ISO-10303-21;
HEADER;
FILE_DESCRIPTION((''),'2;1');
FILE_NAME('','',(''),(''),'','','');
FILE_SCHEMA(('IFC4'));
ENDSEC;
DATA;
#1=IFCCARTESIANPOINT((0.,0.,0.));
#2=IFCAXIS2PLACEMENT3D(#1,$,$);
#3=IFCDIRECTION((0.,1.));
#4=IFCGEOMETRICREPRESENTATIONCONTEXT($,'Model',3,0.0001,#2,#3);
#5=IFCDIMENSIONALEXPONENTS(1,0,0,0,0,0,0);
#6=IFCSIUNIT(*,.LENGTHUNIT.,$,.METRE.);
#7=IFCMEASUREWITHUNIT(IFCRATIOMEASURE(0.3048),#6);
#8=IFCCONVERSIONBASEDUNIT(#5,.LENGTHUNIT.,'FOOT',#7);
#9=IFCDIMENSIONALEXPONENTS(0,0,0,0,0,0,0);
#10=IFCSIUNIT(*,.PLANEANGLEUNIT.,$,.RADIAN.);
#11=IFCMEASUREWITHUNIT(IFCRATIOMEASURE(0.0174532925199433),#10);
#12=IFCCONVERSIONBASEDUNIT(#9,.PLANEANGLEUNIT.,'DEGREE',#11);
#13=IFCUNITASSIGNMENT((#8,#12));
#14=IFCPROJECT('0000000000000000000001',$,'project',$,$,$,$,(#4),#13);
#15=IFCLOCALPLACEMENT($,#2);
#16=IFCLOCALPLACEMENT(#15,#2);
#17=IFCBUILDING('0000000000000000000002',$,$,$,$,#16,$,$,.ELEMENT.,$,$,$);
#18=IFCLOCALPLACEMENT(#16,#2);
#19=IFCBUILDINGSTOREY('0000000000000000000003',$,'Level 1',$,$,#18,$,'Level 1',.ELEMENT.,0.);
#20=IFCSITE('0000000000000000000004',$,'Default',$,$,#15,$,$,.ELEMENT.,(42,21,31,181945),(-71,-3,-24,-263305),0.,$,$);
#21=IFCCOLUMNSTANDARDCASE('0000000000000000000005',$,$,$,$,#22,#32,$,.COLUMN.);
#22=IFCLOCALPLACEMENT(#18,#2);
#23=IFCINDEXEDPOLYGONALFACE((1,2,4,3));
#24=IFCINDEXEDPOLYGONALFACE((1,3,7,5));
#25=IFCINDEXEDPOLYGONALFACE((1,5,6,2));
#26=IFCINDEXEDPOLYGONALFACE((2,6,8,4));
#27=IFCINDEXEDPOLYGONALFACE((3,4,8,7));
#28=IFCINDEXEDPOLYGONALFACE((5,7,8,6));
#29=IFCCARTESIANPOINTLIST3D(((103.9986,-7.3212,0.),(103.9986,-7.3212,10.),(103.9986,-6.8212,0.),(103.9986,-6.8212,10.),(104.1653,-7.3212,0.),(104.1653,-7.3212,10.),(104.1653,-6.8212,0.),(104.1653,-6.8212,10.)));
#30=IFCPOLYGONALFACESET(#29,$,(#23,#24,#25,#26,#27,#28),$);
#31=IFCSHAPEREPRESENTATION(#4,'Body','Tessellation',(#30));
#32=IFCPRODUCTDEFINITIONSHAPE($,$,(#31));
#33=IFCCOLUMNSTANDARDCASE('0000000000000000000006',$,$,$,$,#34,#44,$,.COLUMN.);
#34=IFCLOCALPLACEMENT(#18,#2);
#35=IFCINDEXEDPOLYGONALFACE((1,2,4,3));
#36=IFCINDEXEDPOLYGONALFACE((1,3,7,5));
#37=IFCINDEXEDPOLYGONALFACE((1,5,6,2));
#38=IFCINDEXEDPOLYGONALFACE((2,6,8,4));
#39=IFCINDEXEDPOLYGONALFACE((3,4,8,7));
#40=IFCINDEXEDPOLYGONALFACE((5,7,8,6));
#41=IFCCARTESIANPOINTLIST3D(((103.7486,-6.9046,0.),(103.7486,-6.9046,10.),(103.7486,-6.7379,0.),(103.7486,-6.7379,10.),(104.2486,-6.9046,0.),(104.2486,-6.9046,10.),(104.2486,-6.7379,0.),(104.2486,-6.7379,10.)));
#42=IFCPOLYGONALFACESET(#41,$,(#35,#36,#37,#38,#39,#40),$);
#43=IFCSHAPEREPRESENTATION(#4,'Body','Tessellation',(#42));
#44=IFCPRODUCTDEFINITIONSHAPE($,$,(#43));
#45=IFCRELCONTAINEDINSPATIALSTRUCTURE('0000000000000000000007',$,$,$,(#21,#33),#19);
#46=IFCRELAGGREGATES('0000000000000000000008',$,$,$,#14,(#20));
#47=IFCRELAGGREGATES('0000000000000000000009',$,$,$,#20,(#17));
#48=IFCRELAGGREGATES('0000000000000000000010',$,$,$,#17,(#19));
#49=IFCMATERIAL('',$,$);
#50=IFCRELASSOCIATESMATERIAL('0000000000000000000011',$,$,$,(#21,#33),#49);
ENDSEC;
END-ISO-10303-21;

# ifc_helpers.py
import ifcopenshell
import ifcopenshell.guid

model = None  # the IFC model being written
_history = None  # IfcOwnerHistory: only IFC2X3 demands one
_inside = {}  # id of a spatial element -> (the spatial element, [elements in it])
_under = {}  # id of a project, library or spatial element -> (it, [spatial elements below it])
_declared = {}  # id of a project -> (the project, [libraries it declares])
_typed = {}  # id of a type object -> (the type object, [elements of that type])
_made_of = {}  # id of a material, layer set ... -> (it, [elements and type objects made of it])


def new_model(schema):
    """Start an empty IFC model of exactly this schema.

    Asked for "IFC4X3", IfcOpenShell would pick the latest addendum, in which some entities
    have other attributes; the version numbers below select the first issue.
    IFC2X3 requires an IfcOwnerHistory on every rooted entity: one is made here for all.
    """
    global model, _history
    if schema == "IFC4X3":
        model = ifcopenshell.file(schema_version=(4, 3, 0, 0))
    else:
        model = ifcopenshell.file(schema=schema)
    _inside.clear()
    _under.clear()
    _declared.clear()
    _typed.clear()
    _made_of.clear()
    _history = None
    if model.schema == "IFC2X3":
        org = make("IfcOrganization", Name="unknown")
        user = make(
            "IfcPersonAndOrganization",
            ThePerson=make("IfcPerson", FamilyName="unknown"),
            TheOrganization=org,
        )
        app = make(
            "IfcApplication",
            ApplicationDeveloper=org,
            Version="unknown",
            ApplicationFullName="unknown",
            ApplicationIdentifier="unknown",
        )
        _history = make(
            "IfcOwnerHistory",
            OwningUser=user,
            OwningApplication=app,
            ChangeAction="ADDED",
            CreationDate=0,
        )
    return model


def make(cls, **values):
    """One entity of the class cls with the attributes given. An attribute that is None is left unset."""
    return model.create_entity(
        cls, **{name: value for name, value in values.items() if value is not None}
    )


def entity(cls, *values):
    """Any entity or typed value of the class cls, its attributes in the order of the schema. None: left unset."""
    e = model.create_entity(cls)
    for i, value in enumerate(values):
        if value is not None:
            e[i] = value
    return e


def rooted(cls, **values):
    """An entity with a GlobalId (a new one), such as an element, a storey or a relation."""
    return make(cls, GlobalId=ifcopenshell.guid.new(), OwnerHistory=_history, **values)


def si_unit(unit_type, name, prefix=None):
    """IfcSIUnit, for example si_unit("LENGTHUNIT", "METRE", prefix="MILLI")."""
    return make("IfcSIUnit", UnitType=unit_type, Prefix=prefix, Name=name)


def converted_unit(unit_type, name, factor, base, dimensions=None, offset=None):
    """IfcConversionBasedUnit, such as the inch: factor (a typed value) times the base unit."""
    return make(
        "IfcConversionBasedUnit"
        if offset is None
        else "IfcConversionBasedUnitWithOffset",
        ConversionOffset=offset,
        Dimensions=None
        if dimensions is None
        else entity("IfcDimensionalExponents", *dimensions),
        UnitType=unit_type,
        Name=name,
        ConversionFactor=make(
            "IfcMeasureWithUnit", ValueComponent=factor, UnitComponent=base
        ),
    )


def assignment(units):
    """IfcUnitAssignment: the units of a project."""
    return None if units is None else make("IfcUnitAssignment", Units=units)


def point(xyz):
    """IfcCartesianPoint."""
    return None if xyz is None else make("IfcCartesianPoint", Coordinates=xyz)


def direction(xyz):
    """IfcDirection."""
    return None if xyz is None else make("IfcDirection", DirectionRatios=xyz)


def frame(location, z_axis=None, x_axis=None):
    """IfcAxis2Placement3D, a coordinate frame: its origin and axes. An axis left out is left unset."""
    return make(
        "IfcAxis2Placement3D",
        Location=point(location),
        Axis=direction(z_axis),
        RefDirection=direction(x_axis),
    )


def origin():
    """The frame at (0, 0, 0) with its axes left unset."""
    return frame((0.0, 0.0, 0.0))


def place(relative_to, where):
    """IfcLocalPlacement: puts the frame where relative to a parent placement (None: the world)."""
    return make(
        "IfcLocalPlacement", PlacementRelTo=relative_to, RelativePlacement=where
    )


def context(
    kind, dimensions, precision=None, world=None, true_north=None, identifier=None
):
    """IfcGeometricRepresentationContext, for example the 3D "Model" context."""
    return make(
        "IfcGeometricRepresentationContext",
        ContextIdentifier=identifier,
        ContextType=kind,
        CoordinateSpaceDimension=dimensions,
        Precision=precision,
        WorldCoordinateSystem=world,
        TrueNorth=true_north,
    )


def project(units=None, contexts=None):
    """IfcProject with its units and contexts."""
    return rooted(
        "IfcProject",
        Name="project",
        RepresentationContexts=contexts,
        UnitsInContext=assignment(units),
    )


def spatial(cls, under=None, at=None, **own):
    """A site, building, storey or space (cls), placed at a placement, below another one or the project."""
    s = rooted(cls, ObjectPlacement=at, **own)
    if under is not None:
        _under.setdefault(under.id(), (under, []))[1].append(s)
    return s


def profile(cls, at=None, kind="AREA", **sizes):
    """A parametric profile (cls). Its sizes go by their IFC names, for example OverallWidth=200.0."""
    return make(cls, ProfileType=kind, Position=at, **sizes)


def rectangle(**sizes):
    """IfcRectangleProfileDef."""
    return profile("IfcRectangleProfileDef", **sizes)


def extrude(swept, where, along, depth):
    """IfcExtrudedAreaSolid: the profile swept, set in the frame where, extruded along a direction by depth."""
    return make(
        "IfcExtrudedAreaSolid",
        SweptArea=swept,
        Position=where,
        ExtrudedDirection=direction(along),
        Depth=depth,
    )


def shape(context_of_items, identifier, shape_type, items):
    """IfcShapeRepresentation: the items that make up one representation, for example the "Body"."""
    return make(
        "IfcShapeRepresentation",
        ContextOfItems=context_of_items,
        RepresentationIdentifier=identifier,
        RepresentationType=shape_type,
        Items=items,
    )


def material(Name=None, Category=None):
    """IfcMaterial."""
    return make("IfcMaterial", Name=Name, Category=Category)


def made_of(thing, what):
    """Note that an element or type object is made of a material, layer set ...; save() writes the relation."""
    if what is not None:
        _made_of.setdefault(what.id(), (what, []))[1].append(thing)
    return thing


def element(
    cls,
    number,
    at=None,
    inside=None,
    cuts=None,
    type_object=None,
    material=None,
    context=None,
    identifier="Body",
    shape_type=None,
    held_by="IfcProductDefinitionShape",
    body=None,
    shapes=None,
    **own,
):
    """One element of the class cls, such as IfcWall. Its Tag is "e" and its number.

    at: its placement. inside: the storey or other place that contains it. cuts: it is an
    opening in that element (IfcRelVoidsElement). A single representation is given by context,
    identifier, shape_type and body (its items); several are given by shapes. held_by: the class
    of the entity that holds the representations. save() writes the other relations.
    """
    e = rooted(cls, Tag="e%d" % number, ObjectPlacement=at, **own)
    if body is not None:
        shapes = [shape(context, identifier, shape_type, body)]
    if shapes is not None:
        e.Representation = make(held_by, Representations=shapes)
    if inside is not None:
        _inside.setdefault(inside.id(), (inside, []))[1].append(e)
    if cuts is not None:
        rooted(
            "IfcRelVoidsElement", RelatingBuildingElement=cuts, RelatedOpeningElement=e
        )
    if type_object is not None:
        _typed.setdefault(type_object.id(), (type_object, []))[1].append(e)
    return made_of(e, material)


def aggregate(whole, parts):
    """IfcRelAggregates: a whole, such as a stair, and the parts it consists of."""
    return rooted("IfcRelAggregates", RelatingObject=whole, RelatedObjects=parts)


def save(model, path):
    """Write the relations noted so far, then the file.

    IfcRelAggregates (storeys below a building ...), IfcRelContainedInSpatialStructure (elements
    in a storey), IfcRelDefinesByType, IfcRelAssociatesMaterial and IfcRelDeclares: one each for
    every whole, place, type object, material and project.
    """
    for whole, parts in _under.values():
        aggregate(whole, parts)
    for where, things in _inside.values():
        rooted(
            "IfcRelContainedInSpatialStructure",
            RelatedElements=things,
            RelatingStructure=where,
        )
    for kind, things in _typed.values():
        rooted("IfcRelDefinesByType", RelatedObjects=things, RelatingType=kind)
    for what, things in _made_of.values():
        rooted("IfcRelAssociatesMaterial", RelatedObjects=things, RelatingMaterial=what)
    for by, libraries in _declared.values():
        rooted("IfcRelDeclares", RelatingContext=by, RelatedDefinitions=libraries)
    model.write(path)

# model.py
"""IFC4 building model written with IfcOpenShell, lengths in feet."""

from ifc_helpers import new_model, entity, si_unit, converted_unit, direction, frame, origin, place, context, project, spatial, rectangle, extrude, material, element, save


model = new_model("IFC4")

# Units and contexts
model_context = context("Model", 3, precision=0.0001, world=origin(), true_north=direction((0.0, 1.0)))
ifc_project = project(units=[converted_unit("LENGTHUNIT", "FOOT", entity("IfcRatioMeasure", 0.3048), si_unit("LENGTHUNIT", "METRE"), dimensions=[1, 0, 0, 0, 0, 0, 0]), converted_unit("PLANEANGLEUNIT", "DEGREE", entity("IfcRatioMeasure", 0.0174532925199433), si_unit("PLANEANGLEUNIT", "RADIAN"), dimensions=[0, 0, 0, 0, 0, 0, 0])], contexts=[model_context])

# Site, building, storey
site_placement = place(None, origin())
site = spatial("IfcSite", under=ifc_project, at=site_placement, Name="Default", CompositionType="ELEMENT", RefLatitude=(42, 21, 31, 181945), RefLongitude=(-71, -3, -24, -263305), RefElevation=0.0)
building_placement = place(site_placement, origin())
building = spatial("IfcBuilding", under=site, at=building_placement, CompositionType="ELEMENT")
storey_placement = place(building_placement, origin())
storey = spatial("IfcBuildingStorey", under=building, at=storey_placement, Name="Level 1", LongName="Level 1", CompositionType="ELEMENT", Elevation=0.0)

# Columns
ifc_material = material(Name="")
placement_1 = place(storey_placement, frame((104.1653, -7.0712, 0.0), z_axis=(0.0, 0.0, 1.0), x_axis=(-1.0, 0.0, 0.0)))
for number, where, z_axis, x_axis in (
    (1, (0.0833, 0.0, 0.0), (0.0, 0.0, 1.0), (1.0, 0.0, 0.0)),
):
    element("IfcColumnStandardCase", number, at=place(placement_1, frame(where, z_axis=z_axis, x_axis=x_axis)), inside=storey, material=ifc_material, PredefinedType="COLUMN", context=model_context, shape_type="SweptSolid", body=[
        extrude(rectangle(XDim=0.1667, YDim=0.5), origin(), (0.0, 0.0, 1.0), 10.0),
    ])
placement_2 = place(storey_placement, frame((103.9986, -6.9045, 0.0), z_axis=(0.0, 0.0, 1.0), x_axis=(0.0, 1.0, 0.0)))
for number, where, z_axis, x_axis in (
    (2, (0.0833, 0.0, 0.0), (0.0, 0.0, 1.0), (1.0, 0.0, 0.0)),
):
    element("IfcColumnStandardCase", number, at=place(placement_2, frame(where, z_axis=z_axis, x_axis=x_axis)), inside=storey, material=ifc_material, PredefinedType="COLUMN", context=model_context, shape_type="SweptSolid", body=[
        extrude(rectangle(XDim=0.1667, YDim=0.5), origin(), (0.0, 0.0, 1.0), 10.0),
    ])

save(model, "model.ifc")
